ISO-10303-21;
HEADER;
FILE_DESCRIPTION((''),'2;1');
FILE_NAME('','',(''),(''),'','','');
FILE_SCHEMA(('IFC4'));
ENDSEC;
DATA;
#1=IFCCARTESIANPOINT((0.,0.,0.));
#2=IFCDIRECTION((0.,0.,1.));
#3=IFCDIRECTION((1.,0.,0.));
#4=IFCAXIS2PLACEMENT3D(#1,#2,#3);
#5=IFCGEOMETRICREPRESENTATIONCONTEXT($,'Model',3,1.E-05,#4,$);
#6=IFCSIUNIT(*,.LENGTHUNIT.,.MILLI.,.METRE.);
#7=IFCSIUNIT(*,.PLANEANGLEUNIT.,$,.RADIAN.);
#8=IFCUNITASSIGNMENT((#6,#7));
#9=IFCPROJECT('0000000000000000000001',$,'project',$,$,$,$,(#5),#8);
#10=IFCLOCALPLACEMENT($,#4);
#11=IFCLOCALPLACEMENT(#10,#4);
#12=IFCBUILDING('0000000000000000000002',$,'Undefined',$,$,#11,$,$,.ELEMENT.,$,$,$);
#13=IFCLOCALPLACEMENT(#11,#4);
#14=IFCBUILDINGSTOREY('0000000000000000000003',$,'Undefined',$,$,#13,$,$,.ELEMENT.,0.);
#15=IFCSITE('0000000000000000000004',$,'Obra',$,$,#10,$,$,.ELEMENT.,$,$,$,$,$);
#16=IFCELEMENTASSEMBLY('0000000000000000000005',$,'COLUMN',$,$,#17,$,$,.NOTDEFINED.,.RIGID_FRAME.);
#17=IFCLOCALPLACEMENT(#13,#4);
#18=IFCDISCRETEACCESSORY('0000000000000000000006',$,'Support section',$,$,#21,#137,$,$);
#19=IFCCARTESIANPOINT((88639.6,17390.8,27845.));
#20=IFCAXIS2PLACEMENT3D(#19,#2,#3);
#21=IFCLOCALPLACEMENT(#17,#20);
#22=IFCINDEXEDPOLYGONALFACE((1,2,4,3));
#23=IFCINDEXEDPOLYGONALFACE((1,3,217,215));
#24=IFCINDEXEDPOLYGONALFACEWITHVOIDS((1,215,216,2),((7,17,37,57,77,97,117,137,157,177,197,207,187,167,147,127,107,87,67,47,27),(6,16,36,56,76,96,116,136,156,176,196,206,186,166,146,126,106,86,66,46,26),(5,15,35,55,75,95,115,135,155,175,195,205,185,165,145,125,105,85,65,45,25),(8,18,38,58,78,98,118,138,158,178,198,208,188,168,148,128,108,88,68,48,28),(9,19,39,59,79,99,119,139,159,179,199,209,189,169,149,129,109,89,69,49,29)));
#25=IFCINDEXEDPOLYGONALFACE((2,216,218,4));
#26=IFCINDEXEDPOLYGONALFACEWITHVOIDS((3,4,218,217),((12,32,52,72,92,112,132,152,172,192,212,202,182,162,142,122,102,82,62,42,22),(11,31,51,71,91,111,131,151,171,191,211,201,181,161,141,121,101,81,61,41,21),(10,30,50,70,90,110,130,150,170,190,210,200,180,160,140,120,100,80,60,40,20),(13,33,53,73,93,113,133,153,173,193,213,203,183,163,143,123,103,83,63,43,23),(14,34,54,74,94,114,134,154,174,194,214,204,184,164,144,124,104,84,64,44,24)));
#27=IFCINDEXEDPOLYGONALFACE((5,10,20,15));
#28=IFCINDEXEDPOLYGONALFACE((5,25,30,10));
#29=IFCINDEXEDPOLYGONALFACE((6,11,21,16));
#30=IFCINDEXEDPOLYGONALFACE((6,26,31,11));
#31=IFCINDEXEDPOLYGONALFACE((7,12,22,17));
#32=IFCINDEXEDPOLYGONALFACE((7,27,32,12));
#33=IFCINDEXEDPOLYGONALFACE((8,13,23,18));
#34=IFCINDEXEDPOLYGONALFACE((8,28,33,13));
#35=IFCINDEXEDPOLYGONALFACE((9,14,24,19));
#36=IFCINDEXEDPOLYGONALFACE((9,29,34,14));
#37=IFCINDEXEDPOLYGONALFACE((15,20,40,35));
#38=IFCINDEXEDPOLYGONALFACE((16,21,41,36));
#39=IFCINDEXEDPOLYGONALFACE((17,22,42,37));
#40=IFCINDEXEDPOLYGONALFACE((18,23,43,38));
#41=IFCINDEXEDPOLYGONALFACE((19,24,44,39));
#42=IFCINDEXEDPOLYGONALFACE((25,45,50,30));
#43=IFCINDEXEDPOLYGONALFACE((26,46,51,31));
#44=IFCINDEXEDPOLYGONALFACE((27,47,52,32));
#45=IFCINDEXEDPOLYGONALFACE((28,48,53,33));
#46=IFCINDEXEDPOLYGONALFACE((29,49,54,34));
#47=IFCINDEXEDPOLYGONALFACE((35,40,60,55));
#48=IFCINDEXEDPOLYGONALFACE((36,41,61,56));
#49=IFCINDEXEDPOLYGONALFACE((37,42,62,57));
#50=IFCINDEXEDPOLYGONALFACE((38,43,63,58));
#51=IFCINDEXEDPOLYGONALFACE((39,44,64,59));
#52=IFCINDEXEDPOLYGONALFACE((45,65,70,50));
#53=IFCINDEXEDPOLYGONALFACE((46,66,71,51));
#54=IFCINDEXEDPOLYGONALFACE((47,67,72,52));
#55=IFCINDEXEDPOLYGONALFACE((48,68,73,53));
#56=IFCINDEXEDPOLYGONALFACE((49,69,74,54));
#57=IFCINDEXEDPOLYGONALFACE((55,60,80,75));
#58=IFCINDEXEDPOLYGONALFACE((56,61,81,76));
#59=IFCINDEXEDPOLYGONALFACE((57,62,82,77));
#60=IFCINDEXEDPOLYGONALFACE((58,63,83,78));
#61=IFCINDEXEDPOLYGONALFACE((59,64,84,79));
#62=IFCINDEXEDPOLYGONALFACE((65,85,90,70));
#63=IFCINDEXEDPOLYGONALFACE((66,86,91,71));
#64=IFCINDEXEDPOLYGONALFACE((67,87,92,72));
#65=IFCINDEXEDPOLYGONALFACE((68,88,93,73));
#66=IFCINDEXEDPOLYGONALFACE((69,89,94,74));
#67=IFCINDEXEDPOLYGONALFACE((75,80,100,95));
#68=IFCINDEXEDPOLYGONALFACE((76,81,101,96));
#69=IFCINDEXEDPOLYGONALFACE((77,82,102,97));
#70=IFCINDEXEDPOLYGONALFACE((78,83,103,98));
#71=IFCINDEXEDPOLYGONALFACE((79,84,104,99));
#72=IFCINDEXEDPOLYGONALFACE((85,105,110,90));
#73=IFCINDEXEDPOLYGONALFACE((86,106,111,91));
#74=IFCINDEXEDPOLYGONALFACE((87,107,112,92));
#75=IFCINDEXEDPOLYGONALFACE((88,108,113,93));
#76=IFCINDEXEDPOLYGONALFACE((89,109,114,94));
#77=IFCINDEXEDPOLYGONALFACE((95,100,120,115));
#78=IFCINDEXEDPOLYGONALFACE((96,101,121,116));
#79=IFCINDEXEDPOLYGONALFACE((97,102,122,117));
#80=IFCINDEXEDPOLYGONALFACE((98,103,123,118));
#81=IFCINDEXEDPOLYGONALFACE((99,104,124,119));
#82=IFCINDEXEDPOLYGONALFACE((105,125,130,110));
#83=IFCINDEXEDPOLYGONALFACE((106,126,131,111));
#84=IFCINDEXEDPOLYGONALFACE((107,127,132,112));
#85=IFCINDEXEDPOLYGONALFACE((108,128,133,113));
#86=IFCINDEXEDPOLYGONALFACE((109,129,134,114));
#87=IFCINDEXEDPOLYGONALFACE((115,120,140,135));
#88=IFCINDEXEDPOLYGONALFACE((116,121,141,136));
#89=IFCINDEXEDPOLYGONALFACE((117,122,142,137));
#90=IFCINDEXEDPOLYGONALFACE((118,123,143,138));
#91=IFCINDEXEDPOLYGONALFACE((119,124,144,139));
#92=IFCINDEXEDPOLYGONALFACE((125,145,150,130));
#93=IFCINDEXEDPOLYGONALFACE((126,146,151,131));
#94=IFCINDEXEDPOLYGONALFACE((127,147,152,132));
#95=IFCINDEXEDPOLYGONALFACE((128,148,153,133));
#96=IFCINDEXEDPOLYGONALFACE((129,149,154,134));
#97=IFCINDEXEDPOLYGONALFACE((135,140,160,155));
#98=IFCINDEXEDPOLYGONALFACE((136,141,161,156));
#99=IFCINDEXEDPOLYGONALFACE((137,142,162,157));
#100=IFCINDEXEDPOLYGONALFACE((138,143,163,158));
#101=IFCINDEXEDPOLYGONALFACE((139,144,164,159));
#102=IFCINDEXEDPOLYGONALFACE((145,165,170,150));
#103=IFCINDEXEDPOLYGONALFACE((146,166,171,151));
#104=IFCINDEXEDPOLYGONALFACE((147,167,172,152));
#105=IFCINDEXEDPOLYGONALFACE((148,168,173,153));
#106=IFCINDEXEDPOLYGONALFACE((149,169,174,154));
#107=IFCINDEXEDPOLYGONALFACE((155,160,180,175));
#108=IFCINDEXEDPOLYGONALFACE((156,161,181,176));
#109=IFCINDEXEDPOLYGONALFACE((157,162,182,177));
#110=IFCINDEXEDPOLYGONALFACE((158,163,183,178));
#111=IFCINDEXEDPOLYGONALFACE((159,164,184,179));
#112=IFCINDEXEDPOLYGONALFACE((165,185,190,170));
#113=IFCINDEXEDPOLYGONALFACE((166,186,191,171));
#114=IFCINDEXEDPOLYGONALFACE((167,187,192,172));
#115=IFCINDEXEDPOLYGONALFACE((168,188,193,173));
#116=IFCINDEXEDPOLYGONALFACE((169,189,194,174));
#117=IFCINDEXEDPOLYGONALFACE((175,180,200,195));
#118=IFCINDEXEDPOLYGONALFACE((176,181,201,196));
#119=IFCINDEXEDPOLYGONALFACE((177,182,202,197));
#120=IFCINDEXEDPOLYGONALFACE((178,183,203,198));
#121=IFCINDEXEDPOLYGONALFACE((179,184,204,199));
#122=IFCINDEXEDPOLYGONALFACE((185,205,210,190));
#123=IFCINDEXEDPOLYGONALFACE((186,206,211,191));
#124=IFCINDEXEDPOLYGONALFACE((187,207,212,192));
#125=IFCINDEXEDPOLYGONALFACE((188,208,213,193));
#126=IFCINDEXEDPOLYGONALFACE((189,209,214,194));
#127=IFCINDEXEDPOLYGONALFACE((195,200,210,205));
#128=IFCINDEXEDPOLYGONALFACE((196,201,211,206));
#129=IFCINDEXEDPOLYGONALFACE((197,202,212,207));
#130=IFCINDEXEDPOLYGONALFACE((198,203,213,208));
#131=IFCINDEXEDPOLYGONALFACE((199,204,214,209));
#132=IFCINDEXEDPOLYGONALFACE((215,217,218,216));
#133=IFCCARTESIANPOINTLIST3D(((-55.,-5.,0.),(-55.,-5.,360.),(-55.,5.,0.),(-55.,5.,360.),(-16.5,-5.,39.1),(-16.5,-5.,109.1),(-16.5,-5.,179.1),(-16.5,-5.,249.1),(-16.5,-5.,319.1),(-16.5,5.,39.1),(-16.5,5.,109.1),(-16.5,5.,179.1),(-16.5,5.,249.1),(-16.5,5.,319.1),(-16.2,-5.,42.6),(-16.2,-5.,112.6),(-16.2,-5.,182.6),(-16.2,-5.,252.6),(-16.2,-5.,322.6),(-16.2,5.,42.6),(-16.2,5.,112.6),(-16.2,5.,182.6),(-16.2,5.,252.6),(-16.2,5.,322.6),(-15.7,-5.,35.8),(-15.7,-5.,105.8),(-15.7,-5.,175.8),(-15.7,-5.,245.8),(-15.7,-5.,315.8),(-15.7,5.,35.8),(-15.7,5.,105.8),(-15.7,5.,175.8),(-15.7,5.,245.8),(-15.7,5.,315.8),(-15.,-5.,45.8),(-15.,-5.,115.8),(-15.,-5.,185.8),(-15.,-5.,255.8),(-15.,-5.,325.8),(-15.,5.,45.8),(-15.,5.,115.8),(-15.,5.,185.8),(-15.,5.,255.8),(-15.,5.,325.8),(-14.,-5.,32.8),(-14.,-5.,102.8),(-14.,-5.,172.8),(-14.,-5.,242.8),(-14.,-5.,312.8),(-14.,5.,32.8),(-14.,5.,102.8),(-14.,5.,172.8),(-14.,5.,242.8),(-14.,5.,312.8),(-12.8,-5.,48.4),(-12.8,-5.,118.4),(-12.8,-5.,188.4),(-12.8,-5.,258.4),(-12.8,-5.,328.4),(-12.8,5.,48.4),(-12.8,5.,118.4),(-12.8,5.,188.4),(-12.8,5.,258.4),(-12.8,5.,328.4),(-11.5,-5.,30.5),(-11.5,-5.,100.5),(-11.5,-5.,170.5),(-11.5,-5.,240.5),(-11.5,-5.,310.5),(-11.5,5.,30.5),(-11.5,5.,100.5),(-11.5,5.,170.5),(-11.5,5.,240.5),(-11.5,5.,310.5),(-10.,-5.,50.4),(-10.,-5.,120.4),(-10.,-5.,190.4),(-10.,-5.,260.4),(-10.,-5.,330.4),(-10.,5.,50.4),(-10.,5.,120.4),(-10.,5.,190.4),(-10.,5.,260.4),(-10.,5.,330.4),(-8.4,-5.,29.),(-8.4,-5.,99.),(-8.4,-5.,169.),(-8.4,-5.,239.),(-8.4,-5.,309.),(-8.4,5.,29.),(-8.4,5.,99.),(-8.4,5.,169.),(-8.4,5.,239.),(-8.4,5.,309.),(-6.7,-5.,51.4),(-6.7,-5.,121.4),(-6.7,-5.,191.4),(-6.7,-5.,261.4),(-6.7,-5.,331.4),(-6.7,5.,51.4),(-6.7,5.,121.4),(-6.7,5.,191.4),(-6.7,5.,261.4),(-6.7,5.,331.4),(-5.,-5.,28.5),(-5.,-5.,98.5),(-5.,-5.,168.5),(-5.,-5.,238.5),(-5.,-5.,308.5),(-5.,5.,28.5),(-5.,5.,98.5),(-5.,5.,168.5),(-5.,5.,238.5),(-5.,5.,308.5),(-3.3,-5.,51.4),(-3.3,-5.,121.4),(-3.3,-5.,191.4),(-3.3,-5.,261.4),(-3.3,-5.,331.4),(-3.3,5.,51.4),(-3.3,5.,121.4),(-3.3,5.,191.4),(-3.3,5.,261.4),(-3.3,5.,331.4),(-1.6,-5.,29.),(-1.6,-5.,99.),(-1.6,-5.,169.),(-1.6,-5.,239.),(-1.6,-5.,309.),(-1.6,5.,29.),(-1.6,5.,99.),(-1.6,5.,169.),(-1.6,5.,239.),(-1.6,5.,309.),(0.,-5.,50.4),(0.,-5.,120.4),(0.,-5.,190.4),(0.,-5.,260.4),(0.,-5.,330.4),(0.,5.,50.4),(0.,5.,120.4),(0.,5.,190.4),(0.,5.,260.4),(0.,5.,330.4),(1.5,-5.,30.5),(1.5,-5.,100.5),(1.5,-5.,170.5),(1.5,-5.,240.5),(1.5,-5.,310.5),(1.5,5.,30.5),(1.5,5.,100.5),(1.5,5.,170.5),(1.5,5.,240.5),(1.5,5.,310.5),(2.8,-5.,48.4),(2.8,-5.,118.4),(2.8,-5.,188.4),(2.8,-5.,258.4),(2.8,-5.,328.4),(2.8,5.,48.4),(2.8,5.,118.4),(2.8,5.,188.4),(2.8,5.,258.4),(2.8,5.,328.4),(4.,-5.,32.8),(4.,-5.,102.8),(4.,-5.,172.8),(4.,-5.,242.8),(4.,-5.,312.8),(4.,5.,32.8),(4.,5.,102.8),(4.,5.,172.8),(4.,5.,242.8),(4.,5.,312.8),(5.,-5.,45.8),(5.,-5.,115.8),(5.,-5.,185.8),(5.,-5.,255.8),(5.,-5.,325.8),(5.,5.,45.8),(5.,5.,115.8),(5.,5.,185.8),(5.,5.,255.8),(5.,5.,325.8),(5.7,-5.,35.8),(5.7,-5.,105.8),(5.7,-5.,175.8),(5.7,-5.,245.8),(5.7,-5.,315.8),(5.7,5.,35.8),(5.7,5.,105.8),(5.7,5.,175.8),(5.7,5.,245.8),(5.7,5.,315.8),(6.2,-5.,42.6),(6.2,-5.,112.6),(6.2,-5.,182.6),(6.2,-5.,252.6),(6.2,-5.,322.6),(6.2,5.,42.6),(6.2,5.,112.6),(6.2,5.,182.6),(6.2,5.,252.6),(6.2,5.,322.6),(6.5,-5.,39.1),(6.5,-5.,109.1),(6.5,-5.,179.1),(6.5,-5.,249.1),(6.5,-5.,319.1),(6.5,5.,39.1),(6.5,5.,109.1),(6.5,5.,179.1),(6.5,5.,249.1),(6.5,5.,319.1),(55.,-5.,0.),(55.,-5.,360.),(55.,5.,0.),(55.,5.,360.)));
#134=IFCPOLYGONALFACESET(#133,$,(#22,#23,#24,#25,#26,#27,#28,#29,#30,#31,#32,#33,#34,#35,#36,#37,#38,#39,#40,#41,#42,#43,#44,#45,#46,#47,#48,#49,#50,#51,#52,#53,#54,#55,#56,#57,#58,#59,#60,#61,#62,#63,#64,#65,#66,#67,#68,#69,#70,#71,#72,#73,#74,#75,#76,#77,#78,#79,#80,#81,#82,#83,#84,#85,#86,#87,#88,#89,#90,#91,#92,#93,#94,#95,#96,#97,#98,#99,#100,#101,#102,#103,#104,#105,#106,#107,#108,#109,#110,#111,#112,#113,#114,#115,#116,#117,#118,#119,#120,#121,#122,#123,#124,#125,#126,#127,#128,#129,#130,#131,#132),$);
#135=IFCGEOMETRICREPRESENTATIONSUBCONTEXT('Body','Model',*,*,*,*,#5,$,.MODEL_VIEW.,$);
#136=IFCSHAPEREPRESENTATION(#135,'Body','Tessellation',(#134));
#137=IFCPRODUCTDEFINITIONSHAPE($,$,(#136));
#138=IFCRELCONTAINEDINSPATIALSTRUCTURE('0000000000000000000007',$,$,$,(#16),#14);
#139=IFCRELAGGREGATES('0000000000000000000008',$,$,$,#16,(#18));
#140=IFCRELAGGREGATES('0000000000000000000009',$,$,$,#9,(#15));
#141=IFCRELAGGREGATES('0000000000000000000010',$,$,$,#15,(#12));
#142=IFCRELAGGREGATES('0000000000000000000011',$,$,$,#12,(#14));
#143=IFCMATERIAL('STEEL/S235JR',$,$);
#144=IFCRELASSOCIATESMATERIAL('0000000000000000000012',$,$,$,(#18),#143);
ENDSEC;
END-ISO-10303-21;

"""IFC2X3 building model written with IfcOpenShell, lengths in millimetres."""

from ifc_helpers import new_model, si_unit, frame, origin_with_axes, origin_2d_with_axis, place, context, subcontext, project, spatial, rectangle, circle, extrude, source, transform, mapped, material, element, aggregate, save


model = new_model("IFC2X3")

# Units and contexts
model_context = context("Model", 3, precision=1e-05, world=origin_with_axes())
body_context = subcontext(model_context, "Body", "Model", "MODEL_VIEW")
ifc_project = project(units=[si_unit("LENGTHUNIT", "METRE", prefix="MILLI"), si_unit("PLANEANGLEUNIT", "RADIAN")], contexts=[model_context])

# Site, building, storey
site_placement = place(None, origin_with_axes())
site = spatial("IfcSite", under=ifc_project, at=site_placement, Name="Obra", CompositionType="ELEMENT")
building_placement = place(site_placement, origin_with_axes())
building = spatial("IfcBuilding", under=site, at=building_placement, Name="Undefined", CompositionType="ELEMENT")
storey_placement = place(building_placement, origin_with_axes())
storey = spatial("IfcBuildingStorey", under=building, at=storey_placement, Name="Undefined", CompositionType="ELEMENT", Elevation=0.0)

# Element assembly
ifc_material_1 = material(Name="STEEL/S235JR")
assembly_1_placement = place(storey_placement, origin_with_axes())
assembly_1 = element("IfcElementAssembly", 1, at=assembly_1_placement, inside=storey, Name="COLUMN", AssemblyPlace="NOTDEFINED", PredefinedType="RIGID_FRAME")

# Discrete accessory, opening
shared_shape_1 = source(origin_with_axes(), body_context, "Body", "SweptSolid", [
    extrude(circle(Radius=11.5, at=origin_2d_with_axis()), frame((0.0, -15.7, 0.0), z_axis=(0.0, 1.0, 0.0), x_axis=(1.0, 0.0, 0.0)), (0.0, 0.0, 1.0), 10.2),
])
discrete_accessory_1_placement = place(assembly_1_placement, frame((88639.6, 17390.8, 27845.0), z_axis=(0.0, 0.0, 1.0), x_axis=(1.0, 0.0, 0.0)))
discrete_accessory_1 = element("IfcDiscreteAccessory", 2, at=discrete_accessory_1_placement, material=ifc_material_1, Name="Support section", context=body_context, shape_type="SweptSolid", body=[
    extrude(rectangle(XDim=10.0, YDim=110.0, at=origin_2d_with_axis()), frame((0.0, 0.0, 360.0), z_axis=(0.0, 0.0, -1.0), x_axis=(0.0, 1.0, 0.0)), (0.0, 0.0, 1.0), 360.0),
])
opening_1_placement = place(assembly_1_placement, frame((88684.6, 17380.2, 28300.0), z_axis=(-1.0, 0.0, 0.0), x_axis=(0.0, 0.0, -1.0)))
element("IfcOpeningElement", 3, at=opening_1_placement, cuts=discrete_accessory_1, ObjectType="Opening", context=body_context, shape_type="MappedRepresentation", body=[
    mapped(shared_shape_1, transform((135.0, 0.0, 50.0))),
    mapped(shared_shape_1, transform((205.0, 0.0, 50.0))),
    mapped(shared_shape_1, transform((275.0, 0.0, 50.0))),
    mapped(shared_shape_1, transform((345.0, 0.0, 50.0))),
    mapped(shared_shape_1, transform((415.0, 0.0, 50.0))),
])
aggregate(assembly_1, [discrete_accessory_1])

save(model, "model.ifc")
